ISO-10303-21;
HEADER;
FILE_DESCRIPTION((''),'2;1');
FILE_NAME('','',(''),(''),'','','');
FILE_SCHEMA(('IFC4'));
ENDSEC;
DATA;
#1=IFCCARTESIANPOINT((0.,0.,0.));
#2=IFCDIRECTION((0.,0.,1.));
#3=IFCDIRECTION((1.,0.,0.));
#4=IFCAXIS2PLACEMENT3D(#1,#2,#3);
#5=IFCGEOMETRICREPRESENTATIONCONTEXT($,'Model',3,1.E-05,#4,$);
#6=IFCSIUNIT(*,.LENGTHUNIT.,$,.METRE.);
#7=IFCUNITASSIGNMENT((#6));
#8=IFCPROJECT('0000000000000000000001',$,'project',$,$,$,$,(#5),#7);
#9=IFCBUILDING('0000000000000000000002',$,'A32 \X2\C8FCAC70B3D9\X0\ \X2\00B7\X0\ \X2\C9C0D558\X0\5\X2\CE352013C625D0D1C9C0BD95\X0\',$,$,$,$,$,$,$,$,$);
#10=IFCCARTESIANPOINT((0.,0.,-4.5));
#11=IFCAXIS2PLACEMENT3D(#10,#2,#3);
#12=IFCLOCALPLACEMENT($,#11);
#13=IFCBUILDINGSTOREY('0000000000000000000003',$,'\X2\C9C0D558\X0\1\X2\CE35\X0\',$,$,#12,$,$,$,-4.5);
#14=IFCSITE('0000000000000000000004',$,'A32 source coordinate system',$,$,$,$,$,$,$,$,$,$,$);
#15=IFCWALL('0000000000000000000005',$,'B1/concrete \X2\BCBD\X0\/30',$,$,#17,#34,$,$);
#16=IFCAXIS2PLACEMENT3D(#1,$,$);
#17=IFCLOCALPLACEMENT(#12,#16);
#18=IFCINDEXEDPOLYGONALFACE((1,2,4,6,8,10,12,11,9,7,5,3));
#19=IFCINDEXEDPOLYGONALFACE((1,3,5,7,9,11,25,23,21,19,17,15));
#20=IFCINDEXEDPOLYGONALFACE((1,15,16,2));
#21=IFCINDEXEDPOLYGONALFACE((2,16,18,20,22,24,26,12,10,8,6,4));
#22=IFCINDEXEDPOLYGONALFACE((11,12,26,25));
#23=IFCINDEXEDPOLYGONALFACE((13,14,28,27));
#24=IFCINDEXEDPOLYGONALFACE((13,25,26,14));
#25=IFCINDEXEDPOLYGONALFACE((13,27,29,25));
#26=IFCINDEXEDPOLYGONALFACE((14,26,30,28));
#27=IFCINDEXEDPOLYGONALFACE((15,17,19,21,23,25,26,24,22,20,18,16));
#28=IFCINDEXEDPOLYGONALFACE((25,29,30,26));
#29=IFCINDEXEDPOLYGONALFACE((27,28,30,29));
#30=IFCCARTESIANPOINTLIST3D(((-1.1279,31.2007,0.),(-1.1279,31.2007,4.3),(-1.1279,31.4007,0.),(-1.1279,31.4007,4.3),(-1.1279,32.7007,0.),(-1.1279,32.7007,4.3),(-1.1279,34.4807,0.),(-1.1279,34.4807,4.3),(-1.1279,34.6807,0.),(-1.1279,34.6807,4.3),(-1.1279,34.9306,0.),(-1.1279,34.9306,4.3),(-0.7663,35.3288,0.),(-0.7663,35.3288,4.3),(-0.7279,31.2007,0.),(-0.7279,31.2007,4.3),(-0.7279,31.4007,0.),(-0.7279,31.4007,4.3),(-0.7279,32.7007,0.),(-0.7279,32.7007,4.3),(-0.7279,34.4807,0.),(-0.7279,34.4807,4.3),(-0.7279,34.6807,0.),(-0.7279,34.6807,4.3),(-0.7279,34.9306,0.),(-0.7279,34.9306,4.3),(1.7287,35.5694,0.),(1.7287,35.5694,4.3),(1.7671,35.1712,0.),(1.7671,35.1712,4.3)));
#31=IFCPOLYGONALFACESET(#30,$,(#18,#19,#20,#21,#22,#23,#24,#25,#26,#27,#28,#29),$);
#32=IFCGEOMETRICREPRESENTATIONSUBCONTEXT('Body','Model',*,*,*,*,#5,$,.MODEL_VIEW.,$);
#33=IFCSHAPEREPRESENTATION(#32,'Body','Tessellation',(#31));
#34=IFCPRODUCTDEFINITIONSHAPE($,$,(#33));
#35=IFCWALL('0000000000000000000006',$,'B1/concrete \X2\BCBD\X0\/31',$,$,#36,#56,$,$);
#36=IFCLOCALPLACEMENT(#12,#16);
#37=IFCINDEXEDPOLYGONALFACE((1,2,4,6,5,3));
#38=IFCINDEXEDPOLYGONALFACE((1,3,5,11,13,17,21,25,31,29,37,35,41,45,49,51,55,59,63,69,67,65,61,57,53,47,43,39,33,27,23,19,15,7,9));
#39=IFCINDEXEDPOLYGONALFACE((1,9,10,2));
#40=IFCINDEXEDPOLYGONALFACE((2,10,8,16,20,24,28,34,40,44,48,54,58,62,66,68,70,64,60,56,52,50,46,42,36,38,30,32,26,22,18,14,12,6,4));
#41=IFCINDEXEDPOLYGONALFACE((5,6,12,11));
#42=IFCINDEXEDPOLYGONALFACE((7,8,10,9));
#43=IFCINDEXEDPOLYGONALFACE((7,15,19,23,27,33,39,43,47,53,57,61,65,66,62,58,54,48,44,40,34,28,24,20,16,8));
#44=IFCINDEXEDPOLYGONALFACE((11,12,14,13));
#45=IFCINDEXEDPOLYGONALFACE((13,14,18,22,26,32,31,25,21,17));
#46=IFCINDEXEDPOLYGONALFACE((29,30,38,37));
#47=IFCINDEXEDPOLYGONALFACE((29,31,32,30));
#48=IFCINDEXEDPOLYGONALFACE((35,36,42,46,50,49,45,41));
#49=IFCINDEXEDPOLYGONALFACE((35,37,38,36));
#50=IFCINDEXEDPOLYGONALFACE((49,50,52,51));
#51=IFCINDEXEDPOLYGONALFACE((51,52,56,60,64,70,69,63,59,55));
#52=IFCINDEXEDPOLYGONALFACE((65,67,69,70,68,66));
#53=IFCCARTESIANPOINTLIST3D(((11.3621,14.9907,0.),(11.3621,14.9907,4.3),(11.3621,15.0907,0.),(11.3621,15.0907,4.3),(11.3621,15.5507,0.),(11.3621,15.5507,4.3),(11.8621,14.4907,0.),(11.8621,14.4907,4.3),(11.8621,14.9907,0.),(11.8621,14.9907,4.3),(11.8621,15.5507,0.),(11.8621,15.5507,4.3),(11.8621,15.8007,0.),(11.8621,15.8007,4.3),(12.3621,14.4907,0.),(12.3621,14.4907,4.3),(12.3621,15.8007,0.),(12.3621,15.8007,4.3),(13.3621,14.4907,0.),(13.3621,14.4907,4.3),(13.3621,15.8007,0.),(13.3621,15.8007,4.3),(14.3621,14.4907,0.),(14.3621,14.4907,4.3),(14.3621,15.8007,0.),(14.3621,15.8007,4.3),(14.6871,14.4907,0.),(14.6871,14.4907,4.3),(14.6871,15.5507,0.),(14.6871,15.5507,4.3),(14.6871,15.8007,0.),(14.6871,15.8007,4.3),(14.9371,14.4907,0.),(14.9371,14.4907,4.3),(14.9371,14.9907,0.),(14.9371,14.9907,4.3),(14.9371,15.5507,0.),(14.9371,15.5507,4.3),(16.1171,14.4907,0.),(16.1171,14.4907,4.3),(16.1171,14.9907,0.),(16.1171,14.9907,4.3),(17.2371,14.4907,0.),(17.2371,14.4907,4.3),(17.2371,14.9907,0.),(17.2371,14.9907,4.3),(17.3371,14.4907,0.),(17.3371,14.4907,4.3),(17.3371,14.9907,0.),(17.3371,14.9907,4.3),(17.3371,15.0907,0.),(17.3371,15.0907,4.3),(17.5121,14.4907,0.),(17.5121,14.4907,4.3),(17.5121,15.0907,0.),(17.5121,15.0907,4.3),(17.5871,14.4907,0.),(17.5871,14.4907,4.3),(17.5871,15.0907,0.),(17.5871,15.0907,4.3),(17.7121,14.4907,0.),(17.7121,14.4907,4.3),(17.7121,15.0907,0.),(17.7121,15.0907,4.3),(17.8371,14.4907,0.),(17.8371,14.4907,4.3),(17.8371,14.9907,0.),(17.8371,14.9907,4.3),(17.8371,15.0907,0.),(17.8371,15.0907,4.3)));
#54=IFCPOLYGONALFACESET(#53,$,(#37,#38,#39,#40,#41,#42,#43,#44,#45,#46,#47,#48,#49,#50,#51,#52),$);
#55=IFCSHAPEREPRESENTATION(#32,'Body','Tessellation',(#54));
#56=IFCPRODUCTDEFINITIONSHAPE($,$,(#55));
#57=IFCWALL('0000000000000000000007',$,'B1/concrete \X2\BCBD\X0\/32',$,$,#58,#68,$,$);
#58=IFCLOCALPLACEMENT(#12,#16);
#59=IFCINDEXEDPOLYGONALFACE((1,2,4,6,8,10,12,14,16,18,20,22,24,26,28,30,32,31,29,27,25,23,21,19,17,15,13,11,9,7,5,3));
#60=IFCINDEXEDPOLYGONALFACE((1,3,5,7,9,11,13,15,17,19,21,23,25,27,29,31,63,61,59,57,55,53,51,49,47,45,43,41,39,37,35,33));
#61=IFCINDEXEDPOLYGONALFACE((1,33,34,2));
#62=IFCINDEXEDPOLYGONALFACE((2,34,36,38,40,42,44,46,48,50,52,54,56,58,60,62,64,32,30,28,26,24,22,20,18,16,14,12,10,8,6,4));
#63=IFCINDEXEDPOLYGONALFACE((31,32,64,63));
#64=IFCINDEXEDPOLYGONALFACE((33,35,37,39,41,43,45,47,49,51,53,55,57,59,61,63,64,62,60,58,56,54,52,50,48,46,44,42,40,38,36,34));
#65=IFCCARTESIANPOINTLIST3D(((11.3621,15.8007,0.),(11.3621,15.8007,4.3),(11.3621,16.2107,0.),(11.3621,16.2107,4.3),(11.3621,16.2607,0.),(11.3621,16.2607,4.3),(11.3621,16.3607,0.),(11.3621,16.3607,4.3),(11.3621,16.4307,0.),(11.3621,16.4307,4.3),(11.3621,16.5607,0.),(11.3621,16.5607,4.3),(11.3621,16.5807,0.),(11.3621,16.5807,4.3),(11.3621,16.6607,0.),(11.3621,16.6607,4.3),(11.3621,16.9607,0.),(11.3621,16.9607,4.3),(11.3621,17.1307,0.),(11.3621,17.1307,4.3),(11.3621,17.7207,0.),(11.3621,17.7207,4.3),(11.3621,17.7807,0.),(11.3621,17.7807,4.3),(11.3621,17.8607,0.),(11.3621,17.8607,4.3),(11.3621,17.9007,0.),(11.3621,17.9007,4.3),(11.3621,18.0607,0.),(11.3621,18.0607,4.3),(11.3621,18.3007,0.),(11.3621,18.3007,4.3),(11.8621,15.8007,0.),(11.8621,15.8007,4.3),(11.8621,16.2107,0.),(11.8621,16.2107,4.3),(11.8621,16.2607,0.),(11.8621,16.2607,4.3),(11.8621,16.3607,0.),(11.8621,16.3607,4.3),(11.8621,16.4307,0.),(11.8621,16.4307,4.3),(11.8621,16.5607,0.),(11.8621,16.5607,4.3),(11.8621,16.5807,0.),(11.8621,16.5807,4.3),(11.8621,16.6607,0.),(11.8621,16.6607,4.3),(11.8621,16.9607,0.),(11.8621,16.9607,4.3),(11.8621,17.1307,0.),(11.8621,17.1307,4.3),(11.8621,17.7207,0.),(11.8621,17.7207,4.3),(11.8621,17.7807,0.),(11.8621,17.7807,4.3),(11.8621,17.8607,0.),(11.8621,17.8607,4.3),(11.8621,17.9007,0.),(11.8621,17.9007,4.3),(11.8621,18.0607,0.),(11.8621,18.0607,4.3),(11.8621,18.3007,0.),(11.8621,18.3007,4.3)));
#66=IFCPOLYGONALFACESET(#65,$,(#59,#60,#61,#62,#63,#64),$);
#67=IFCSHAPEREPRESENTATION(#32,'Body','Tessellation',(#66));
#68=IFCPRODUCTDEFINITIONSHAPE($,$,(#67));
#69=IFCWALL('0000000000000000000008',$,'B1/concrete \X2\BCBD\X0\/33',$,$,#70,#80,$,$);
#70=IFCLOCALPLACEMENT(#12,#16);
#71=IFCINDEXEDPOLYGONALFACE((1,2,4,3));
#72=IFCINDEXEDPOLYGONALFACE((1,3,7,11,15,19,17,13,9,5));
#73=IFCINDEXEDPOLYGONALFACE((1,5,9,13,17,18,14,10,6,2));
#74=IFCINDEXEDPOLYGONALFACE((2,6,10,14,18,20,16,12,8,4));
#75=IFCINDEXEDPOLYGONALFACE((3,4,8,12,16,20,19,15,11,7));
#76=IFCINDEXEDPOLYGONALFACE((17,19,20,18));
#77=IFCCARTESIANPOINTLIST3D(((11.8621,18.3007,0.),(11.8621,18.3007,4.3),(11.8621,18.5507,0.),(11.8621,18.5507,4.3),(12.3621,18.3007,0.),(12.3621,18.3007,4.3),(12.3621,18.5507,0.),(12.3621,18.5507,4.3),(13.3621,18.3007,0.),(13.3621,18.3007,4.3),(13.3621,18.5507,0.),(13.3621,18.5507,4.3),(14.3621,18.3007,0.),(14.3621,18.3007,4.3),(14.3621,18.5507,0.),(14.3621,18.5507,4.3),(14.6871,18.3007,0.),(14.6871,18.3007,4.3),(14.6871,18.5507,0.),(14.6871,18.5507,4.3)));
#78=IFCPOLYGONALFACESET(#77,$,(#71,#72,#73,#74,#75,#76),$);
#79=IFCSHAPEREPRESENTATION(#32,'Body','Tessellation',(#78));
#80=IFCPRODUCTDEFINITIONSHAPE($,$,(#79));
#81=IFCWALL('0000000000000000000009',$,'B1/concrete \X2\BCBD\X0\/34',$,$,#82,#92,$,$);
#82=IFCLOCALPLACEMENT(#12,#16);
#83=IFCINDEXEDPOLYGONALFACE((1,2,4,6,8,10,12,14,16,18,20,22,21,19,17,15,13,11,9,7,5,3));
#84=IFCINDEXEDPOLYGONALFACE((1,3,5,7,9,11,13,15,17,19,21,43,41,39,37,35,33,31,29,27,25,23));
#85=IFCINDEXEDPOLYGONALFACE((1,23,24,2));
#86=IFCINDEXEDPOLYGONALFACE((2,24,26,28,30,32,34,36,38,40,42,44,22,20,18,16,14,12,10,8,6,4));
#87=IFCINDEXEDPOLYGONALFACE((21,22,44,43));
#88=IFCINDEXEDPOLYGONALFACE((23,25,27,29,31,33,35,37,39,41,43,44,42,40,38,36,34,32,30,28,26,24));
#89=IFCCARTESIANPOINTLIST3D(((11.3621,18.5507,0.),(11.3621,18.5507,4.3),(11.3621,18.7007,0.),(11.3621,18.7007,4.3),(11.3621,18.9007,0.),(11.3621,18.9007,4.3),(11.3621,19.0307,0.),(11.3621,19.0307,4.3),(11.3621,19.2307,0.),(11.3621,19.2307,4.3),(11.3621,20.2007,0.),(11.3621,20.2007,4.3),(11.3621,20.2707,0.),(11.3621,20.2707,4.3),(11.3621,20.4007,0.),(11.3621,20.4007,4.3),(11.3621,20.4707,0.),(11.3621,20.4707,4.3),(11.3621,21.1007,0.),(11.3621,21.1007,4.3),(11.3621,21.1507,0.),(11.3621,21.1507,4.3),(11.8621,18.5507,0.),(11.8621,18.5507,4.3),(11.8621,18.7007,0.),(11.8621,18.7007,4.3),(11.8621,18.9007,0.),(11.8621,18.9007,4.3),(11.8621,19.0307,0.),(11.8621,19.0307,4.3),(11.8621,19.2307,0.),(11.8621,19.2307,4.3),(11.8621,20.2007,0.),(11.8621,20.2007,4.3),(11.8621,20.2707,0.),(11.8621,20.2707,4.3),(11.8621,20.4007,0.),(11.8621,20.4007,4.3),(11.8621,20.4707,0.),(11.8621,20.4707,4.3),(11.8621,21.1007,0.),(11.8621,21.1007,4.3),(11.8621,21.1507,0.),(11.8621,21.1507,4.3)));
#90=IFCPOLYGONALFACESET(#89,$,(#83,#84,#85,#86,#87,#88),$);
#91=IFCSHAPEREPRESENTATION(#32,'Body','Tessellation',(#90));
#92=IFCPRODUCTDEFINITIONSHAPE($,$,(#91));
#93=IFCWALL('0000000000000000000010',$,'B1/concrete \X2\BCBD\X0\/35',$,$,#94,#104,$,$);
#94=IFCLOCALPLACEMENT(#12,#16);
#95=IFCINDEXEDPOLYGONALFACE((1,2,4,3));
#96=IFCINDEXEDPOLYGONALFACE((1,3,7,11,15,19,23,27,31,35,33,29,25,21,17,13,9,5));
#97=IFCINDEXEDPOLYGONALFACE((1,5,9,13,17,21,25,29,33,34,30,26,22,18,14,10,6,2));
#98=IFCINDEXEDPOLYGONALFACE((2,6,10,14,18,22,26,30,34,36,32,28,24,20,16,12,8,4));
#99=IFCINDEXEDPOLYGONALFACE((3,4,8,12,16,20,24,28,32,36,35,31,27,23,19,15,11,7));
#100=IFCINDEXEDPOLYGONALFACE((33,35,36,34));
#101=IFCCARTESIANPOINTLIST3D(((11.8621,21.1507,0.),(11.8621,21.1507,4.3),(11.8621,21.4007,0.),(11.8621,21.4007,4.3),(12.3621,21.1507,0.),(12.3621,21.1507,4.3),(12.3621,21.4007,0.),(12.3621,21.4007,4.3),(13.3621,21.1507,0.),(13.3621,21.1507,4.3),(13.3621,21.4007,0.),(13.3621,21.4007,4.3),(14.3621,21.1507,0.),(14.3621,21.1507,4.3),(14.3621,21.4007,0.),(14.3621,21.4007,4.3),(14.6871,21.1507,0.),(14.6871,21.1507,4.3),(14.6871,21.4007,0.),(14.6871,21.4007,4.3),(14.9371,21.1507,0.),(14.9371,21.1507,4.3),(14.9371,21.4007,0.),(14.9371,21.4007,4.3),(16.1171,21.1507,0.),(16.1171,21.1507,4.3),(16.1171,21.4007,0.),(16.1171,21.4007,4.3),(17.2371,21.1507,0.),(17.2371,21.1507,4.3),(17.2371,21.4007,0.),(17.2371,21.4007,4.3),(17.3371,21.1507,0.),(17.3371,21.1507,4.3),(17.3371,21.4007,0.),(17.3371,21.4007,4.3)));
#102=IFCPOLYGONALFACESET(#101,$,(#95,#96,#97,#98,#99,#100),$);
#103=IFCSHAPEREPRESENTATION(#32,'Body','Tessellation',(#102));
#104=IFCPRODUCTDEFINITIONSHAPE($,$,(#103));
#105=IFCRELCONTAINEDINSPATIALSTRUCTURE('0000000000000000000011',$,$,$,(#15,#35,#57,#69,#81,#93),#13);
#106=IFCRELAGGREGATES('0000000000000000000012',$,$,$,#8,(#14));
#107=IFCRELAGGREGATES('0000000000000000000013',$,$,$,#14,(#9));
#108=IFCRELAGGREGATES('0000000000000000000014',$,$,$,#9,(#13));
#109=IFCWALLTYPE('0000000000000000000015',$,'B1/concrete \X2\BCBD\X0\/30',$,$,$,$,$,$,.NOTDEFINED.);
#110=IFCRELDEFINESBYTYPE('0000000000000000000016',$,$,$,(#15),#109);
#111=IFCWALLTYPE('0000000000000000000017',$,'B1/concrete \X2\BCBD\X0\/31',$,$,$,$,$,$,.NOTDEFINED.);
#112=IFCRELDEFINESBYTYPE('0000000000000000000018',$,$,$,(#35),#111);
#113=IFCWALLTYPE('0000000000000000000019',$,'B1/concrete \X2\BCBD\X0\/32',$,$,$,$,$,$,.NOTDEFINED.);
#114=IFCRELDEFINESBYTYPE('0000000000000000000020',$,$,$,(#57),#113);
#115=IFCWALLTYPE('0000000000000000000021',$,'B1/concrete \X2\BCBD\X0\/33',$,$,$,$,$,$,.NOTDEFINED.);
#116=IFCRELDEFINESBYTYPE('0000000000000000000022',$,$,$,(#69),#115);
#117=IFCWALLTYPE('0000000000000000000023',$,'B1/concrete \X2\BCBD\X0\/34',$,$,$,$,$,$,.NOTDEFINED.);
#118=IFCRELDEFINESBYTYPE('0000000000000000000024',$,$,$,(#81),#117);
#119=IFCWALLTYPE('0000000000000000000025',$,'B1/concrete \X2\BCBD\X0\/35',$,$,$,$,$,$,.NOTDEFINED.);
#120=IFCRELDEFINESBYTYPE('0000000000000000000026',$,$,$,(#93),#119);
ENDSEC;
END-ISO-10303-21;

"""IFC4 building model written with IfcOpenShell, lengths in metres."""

from ifc_helpers import new_model, si_unit, frame, origin, origin_with_axes, place, context, subcontext, project, spatial, polyline, outline, extrude, source, transform, mapped, type_object, type_shapes, element, save


model = new_model("IFC4")

# Units and contexts
model_context = context("Model", 3, precision=1e-05, world=origin_with_axes())
body_context = subcontext(model_context, "Body", "Model", "MODEL_VIEW")
ifc_project = project(units=[si_unit("LENGTHUNIT", "METRE")], contexts=[model_context])

# Site, building, storey
site = spatial("IfcSite", under=ifc_project, Name="A32 source coordinate system")
building = spatial("IfcBuilding", under=site, Name="A32 주거동 · 지하5층–옥탑지붕")
storey_placement = place(None, frame((0.0, 0.0, -4.5), z_axis=(0.0, 0.0, 1.0), x_axis=(1.0, 0.0, 0.0)))
storey = spatial("IfcBuildingStorey", under=building, at=storey_placement, Name="지하1층", Elevation=-4.5)

# Walls
wall_type_1 = type_object("IfcWallType", Name="B1/concrete 벽/30", PredefinedType="NOTDEFINED")
shared_shape_1 = source(origin(), body_context, "Body", "SweptSolid", [
    extrude(outline(polyline([(-1.1279, 32.7007), (-1.1279, 34.4807), (-1.1279, 34.6807), (-1.1279, 34.9306), (-0.7279, 34.9306), (-0.7663, 35.3288), (1.7287, 35.5694), (1.7671, 35.1712), (-0.7279, 34.9306), (-0.7279, 34.9306), (-0.7279, 34.6807), (-0.7279, 34.4807), (-0.7279, 32.7007), (-0.7279, 31.4007), (-0.7279, 31.2007), (-1.1279, 31.2007), (-1.1279, 31.4007), (-1.1279, 32.7007)])), origin(), (0.0, 0.0, 1.0), 4.3),
])
type_shapes(wall_type_1, [shared_shape_1])
wall_1_placement = place(storey_placement, origin_with_axes())
element("IfcWall", 1, at=wall_1_placement, inside=storey, type_object=wall_type_1, Name="B1/concrete 벽/30", context=body_context, shape_type="MappedRepresentation", body=[
    mapped(shared_shape_1, transform((0.0, 0.0, 0.0), scale=1.0)),
])
wall_type_2 = type_object("IfcWallType", Name="B1/concrete 벽/31", PredefinedType="NOTDEFINED")
shared_shape_2 = source(origin(), body_context, "Body", "SweptSolid", [
    extrude(outline(polyline([(11.8621, 15.5507), (11.8621, 15.8007), (12.3621, 15.8007), (13.3621, 15.8007), (14.3621, 15.8007), (14.6871, 15.8007), (14.6871, 15.5507), (14.9371, 15.5507), (14.9371, 14.9907), (16.1171, 14.9907), (17.2371, 14.9907), (17.3371, 14.9907), (17.3371, 15.0907), (17.5121, 15.0907), (17.5871, 15.0907), (17.7121, 15.0907), (17.8371, 15.0907), (17.8371, 14.9907), (17.8371, 14.4907), (17.7121, 14.4907), (17.5871, 14.4907), (17.5121, 14.4907), (17.3371, 14.4907), (17.2371, 14.4907), (16.1171, 14.4907), (14.9371, 14.4907), (14.6871, 14.4907), (14.3621, 14.4907), (13.3621, 14.4907), (12.3621, 14.4907), (11.8621, 14.4907), (11.8621, 14.9907), (11.3621, 14.9907), (11.3621, 15.0907), (11.3621, 15.5507), (11.8621, 15.5507)])), origin(), (0.0, 0.0, 1.0), 4.3),
])
type_shapes(wall_type_2, [shared_shape_2])
wall_2_placement = place(storey_placement, origin_with_axes())
element("IfcWall", 2, at=wall_2_placement, inside=storey, type_object=wall_type_2, Name="B1/concrete 벽/31", context=body_context, shape_type="MappedRepresentation", body=[
    mapped(shared_shape_2, transform((0.0, 0.0, 0.0), scale=1.0)),
])
wall_type_3 = type_object("IfcWallType", Name="B1/concrete 벽/32", PredefinedType="NOTDEFINED")
shared_shape_3 = source(origin(), body_context, "Body", "SweptSolid", [
    extrude(outline(polyline([(11.3621, 16.2607), (11.3621, 16.3607), (11.3621, 16.4307), (11.3621, 16.5607), (11.3621, 16.5807), (11.3621, 16.6607), (11.3621, 16.9607), (11.3621, 17.1307), (11.3621, 17.7207), (11.3621, 17.7807), (11.3621, 17.8607), (11.3621, 17.9007), (11.3621, 18.0607), (11.3621, 18.3007), (11.8621, 18.3007), (11.8621, 18.0607), (11.8621, 17.9007), (11.8621, 17.8607), (11.8621, 17.7807), (11.8621, 17.7207), (11.8621, 17.1307), (11.8621, 16.9607), (11.8621, 16.6607), (11.8621, 16.5807), (11.8621, 16.5607), (11.8621, 16.4307), (11.8621, 16.3607), (11.8621, 16.2607), (11.8621, 16.2107), (11.8621, 15.8007), (11.3621, 15.8007), (11.3621, 16.2107), (11.3621, 16.2607)])), origin(), (0.0, 0.0, 1.0), 4.3),
])
type_shapes(wall_type_3, [shared_shape_3])
wall_3_placement = place(storey_placement, origin_with_axes())
element("IfcWall", 3, at=wall_3_placement, inside=storey, type_object=wall_type_3, Name="B1/concrete 벽/32", context=body_context, shape_type="MappedRepresentation", body=[
    mapped(shared_shape_3, transform((0.0, 0.0, 0.0), scale=1.0)),
])
wall_type_4 = type_object("IfcWallType", Name="B1/concrete 벽/33", PredefinedType="NOTDEFINED")
shared_shape_4 = source(origin(), body_context, "Body", "SweptSolid", [
    extrude(outline(polyline([(13.3621, 18.5507), (14.3621, 18.5507), (14.6871, 18.5507), (14.6871, 18.3007), (14.3621, 18.3007), (13.3621, 18.3007), (12.3621, 18.3007), (11.8621, 18.3007), (11.8621, 18.5507), (12.3621, 18.5507), (13.3621, 18.5507)])), origin(), (0.0, 0.0, 1.0), 4.3),
])
type_shapes(wall_type_4, [shared_shape_4])
wall_4_placement = place(storey_placement, origin_with_axes())
element("IfcWall", 4, at=wall_4_placement, inside=storey, type_object=wall_type_4, Name="B1/concrete 벽/33", context=body_context, shape_type="MappedRepresentation", body=[
    mapped(shared_shape_4, transform((0.0, 0.0, 0.0), scale=1.0)),
])
wall_type_5 = type_object("IfcWallType", Name="B1/concrete 벽/34", PredefinedType="NOTDEFINED")
shared_shape_5 = source(origin(), body_context, "Body", "SweptSolid", [
    extrude(outline(polyline([(11.3621, 18.9007), (11.3621, 19.0307), (11.3621, 19.2307), (11.3621, 20.2007), (11.3621, 20.2707), (11.3621, 20.4007), (11.3621, 20.4707), (11.3621, 21.1007), (11.3621, 21.1507), (11.8621, 21.1507), (11.8621, 21.1007), (11.8621, 20.4707), (11.8621, 20.4007), (11.8621, 20.2707), (11.8621, 20.2007), (11.8621, 19.2307), (11.8621, 19.0307), (11.8621, 18.9007), (11.8621, 18.7007), (11.8621, 18.5507), (11.3621, 18.5507), (11.3621, 18.7007), (11.3621, 18.9007)])), origin(), (0.0, 0.0, 1.0), 4.3),
])
type_shapes(wall_type_5, [shared_shape_5])
wall_5_placement = place(storey_placement, origin_with_axes())
element("IfcWall", 5, at=wall_5_placement, inside=storey, type_object=wall_type_5, Name="B1/concrete 벽/34", context=body_context, shape_type="MappedRepresentation", body=[
    mapped(shared_shape_5, transform((0.0, 0.0, 0.0), scale=1.0)),
])
wall_type_6 = type_object("IfcWallType", Name="B1/concrete 벽/35", PredefinedType="NOTDEFINED")
shared_shape_6 = source(origin(), body_context, "Body", "SweptSolid", [
    extrude(outline(polyline([(13.3621, 21.4007), (14.3621, 21.4007), (14.6871, 21.4007), (14.9371, 21.4007), (16.1171, 21.4007), (17.2371, 21.4007), (17.3371, 21.4007), (17.3371, 21.1507), (17.2371, 21.1507), (16.1171, 21.1507), (14.9371, 21.1507), (14.6871, 21.1507), (14.3621, 21.1507), (13.3621, 21.1507), (12.3621, 21.1507), (11.8621, 21.1507), (11.8621, 21.4007), (12.3621, 21.4007), (13.3621, 21.4007)])), origin(), (0.0, 0.0, 1.0), 4.3),
])
type_shapes(wall_type_6, [shared_shape_6])
wall_6_placement = place(storey_placement, origin_with_axes())
element("IfcWall", 6, at=wall_6_placement, inside=storey, type_object=wall_type_6, Name="B1/concrete 벽/35", context=body_context, shape_type="MappedRepresentation", body=[
    mapped(shared_shape_6, transform((0.0, 0.0, 0.0), scale=1.0)),
])

save(model, "model.ifc")
